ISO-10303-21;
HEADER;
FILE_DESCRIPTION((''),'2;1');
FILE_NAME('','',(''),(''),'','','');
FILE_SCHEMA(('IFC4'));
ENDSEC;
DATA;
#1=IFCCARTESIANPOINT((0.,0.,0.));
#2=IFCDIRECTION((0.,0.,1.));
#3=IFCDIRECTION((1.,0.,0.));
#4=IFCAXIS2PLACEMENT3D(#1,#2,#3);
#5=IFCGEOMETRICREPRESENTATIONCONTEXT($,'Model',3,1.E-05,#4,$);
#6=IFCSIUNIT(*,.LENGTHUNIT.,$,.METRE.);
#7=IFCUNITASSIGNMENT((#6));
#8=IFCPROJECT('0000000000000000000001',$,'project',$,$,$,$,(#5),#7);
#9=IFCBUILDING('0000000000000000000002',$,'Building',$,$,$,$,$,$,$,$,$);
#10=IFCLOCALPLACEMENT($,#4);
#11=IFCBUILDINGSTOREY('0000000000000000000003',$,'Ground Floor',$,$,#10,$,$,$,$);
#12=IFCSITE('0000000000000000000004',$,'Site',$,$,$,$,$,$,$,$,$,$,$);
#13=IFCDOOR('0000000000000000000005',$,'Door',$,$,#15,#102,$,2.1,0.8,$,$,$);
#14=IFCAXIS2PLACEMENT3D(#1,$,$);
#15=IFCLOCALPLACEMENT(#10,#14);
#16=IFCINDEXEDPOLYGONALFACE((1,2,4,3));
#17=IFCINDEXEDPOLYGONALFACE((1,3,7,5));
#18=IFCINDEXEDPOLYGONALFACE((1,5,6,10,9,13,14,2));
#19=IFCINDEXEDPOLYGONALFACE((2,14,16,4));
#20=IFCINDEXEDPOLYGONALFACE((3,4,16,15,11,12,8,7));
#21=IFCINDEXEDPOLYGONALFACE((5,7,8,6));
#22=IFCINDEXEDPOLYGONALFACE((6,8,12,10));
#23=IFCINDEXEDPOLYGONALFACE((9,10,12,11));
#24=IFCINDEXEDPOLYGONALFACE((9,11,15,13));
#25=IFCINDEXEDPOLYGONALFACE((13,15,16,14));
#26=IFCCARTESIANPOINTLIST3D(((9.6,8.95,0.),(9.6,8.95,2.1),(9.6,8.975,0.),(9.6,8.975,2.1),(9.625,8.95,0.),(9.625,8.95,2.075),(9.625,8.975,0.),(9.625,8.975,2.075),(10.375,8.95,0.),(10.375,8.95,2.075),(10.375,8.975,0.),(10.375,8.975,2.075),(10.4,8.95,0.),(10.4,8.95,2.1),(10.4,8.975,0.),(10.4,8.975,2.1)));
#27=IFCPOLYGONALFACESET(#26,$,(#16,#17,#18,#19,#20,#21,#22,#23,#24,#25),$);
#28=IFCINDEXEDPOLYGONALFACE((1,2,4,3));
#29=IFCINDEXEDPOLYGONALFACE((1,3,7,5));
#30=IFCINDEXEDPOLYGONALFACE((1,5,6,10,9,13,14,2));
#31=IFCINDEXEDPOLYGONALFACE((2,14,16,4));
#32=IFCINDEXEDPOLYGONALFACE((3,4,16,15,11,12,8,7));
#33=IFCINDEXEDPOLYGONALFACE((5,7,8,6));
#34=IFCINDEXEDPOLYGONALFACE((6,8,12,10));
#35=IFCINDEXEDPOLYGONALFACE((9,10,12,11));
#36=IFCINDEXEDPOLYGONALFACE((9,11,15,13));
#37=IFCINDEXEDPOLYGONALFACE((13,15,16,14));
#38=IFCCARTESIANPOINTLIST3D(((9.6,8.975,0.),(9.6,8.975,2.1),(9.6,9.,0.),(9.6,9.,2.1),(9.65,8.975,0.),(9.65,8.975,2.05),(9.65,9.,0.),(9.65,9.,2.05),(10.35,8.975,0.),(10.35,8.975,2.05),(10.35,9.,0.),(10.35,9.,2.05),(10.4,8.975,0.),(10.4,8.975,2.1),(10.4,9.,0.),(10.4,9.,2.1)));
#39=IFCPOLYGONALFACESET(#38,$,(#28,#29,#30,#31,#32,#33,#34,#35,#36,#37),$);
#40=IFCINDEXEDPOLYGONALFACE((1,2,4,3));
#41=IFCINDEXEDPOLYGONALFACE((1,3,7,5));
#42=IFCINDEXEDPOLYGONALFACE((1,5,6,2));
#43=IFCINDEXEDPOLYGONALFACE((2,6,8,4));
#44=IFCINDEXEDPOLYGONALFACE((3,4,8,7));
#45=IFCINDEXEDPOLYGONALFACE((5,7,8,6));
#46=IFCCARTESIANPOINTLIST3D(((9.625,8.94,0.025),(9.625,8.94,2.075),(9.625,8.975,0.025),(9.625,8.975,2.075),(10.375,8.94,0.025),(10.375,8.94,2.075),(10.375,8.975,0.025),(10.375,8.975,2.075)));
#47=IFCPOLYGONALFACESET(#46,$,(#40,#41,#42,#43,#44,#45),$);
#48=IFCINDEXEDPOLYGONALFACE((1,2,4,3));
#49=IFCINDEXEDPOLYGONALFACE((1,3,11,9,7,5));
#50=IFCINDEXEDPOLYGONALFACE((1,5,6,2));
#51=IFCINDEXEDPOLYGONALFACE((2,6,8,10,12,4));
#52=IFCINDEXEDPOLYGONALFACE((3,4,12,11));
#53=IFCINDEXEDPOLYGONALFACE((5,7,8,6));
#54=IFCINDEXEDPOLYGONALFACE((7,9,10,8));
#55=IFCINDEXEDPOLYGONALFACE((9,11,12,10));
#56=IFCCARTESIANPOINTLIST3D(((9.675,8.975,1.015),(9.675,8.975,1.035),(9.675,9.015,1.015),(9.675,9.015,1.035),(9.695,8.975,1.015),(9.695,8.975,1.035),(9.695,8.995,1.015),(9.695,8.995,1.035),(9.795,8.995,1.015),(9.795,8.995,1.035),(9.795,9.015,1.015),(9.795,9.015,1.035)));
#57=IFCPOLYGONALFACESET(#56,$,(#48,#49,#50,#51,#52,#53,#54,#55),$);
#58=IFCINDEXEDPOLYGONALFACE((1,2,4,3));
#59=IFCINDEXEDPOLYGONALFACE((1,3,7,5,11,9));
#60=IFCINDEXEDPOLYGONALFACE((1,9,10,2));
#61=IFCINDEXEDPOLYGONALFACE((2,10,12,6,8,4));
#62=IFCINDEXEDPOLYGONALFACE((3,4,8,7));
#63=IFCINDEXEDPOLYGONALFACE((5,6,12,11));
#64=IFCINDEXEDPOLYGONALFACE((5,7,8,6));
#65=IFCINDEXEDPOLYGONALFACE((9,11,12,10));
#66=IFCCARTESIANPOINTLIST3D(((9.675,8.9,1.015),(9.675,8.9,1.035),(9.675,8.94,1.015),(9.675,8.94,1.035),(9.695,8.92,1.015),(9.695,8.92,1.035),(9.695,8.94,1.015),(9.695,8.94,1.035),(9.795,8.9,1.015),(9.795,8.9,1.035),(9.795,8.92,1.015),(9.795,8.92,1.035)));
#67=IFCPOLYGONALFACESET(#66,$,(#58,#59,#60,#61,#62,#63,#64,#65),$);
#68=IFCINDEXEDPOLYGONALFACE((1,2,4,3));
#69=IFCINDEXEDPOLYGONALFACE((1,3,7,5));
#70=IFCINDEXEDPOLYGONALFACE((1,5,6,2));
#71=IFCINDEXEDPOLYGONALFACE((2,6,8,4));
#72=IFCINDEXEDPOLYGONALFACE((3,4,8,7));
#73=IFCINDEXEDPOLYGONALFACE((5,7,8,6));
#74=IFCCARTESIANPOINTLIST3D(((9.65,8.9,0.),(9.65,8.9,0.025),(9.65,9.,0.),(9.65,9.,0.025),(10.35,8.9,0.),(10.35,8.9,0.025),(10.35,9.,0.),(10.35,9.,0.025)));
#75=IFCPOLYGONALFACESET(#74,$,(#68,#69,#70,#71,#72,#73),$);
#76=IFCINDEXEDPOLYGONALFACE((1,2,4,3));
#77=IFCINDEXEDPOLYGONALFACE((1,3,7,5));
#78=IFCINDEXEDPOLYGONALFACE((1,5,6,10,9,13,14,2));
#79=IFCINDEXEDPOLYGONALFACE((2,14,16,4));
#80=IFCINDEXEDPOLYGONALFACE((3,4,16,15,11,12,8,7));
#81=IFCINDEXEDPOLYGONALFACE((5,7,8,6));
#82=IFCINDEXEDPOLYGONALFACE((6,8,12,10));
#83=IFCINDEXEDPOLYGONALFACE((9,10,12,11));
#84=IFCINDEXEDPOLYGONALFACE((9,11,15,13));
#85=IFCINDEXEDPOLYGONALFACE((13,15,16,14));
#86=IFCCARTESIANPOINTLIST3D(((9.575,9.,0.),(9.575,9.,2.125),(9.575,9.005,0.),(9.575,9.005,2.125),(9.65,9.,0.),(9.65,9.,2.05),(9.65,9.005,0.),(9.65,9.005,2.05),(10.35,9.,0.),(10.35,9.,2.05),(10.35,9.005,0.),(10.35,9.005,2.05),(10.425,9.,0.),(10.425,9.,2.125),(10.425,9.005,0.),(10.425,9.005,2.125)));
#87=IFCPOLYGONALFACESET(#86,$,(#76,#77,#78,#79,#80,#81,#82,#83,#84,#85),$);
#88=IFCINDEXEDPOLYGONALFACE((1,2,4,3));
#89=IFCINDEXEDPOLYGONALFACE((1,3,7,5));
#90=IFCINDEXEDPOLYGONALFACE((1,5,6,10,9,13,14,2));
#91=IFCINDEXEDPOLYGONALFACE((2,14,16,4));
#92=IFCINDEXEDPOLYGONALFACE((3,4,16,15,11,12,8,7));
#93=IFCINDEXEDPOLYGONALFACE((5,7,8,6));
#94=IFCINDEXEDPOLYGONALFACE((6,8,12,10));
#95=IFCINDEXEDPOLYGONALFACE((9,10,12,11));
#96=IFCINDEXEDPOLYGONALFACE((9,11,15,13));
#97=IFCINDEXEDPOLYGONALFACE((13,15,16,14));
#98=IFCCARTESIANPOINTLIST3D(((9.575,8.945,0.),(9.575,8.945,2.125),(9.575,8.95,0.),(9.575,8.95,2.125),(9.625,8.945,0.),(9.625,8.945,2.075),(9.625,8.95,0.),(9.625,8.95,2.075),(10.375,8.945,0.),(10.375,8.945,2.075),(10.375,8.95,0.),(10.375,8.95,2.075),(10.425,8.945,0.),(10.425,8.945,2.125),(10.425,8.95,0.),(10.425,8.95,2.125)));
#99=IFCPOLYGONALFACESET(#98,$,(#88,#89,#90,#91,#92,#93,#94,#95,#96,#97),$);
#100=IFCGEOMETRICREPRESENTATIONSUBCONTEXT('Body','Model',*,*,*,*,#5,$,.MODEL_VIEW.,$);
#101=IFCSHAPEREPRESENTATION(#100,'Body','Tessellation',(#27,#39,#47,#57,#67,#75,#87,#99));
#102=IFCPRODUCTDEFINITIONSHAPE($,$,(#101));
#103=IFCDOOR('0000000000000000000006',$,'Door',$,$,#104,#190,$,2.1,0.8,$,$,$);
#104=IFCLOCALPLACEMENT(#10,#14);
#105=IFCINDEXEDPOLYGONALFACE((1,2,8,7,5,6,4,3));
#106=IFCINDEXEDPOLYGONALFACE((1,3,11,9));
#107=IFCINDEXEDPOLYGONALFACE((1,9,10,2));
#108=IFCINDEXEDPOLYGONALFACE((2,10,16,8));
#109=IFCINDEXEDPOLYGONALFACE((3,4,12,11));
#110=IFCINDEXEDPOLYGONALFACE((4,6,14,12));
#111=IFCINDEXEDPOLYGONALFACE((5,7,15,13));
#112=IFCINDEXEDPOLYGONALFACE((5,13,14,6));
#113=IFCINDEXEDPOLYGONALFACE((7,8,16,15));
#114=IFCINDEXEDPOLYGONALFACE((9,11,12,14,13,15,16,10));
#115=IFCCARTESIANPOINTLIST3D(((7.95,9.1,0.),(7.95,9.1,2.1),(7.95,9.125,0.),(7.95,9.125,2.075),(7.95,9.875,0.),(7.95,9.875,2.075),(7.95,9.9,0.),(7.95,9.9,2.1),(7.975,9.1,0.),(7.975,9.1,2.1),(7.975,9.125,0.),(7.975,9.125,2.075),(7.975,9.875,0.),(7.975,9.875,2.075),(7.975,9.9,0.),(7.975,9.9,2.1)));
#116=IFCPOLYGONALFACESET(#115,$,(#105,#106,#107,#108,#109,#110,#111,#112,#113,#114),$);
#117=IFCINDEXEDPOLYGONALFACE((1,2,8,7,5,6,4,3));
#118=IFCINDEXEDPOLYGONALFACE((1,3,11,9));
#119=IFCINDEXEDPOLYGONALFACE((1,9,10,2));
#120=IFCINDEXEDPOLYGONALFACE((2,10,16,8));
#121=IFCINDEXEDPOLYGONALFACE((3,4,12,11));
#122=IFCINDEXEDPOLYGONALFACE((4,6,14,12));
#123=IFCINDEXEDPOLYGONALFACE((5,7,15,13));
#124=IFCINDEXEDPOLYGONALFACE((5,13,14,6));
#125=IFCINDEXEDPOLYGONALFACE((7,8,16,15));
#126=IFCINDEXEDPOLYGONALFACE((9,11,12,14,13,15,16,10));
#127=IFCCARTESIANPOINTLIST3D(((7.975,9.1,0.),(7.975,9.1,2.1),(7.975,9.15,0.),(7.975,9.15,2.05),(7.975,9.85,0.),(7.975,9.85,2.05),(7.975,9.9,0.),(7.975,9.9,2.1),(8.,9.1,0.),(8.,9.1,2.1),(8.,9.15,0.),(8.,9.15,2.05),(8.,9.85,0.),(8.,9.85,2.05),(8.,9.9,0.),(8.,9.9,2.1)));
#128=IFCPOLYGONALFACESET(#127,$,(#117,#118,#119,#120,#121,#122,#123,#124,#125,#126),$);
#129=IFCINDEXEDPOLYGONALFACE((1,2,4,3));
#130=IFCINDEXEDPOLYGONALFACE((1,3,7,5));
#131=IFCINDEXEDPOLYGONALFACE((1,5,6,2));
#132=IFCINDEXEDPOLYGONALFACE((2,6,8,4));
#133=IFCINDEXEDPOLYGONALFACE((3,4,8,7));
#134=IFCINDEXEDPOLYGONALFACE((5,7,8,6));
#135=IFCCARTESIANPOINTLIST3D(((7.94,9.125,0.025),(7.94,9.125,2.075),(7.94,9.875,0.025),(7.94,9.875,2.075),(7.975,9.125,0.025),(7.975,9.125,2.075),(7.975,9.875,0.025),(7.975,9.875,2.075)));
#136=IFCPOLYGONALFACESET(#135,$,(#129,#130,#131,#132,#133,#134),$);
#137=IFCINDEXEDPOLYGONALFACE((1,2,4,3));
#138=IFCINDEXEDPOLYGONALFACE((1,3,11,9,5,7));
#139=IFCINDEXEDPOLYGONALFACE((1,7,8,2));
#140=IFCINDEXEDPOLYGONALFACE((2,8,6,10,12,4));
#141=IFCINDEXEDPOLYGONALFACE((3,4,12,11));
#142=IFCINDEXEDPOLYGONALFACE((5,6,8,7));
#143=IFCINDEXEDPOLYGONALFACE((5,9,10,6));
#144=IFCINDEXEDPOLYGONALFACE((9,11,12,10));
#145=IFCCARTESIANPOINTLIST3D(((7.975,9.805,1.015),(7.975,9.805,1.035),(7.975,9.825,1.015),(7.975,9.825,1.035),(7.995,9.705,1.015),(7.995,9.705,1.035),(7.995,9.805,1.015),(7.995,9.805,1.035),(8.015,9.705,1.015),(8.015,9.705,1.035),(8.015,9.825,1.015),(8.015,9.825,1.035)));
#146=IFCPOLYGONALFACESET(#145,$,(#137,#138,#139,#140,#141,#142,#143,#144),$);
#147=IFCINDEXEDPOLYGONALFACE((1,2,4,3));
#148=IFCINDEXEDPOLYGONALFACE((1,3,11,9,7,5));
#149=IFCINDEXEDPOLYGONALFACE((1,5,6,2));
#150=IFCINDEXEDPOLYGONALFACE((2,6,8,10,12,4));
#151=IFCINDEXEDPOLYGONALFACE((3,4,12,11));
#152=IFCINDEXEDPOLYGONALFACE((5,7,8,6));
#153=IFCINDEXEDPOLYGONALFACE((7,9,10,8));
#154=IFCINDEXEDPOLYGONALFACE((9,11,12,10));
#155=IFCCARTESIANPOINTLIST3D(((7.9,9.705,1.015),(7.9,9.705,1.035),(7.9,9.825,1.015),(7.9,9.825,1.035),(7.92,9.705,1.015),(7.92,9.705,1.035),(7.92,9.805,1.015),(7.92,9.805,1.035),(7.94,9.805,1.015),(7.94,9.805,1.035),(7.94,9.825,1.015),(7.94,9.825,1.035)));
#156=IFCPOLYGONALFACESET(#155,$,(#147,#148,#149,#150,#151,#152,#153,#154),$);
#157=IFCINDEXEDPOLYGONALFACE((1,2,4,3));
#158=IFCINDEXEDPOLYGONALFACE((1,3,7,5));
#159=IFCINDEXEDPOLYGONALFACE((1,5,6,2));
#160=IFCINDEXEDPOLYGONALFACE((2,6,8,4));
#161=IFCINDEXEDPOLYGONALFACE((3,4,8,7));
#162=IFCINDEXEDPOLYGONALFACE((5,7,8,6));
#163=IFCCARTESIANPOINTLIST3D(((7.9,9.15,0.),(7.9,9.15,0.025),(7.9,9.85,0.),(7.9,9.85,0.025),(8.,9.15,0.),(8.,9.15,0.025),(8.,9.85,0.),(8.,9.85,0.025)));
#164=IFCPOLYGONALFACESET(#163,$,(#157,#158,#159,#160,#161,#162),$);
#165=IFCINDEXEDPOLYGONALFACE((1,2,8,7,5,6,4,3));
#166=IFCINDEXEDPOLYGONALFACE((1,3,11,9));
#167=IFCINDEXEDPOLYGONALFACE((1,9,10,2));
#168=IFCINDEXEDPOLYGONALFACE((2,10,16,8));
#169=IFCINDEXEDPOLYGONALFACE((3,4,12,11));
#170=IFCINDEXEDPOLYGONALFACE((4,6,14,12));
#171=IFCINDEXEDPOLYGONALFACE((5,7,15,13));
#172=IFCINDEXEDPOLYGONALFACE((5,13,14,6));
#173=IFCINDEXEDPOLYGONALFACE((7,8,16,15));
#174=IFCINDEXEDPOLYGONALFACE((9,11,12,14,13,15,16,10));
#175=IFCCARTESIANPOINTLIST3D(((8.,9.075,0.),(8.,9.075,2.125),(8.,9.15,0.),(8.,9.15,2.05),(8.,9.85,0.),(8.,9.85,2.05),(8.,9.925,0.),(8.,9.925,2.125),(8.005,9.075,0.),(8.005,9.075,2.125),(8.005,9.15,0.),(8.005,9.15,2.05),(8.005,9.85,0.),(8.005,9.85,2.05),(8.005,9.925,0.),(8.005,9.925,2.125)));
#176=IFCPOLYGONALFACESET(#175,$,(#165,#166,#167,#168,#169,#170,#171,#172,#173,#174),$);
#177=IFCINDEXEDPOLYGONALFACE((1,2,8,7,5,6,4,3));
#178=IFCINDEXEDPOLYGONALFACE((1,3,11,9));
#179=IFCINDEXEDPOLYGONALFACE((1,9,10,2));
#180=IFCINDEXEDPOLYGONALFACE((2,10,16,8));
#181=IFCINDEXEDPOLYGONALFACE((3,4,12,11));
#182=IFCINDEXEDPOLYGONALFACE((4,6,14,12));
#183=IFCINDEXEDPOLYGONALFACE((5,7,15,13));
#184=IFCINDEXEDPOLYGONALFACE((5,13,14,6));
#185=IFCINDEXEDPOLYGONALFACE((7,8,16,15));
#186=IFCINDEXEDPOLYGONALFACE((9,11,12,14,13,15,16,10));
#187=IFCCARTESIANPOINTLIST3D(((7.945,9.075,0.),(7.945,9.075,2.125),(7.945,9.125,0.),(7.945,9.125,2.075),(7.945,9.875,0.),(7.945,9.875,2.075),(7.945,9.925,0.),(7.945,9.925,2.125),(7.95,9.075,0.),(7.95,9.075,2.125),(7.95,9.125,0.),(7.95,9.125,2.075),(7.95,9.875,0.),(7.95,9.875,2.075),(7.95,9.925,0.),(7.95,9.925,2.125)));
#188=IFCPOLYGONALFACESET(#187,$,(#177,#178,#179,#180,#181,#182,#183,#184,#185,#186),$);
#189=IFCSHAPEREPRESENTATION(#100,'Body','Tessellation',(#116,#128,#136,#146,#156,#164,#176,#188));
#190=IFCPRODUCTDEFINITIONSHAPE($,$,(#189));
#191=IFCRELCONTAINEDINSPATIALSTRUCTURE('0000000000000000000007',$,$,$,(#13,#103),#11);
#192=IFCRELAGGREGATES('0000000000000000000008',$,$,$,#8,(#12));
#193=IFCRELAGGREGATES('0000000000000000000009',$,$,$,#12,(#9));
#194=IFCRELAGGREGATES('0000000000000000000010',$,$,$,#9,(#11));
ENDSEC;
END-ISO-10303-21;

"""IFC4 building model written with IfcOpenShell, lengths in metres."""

from ifc_helpers import new_model, si_unit, frame, origin_with_axes, place, context, subcontext, project, spatial, line, indexed_curve, outline, extrude, element, save


model = new_model("IFC4")

# Units and contexts
model_context = context("Model", 3, precision=1e-05, world=origin_with_axes())
body_context = subcontext(model_context, "Body", "Model", "MODEL_VIEW")
ifc_project = project(units=[si_unit("LENGTHUNIT", "METRE")], contexts=[model_context])

# Site, building, storey
site = spatial("IfcSite", under=ifc_project, Name="Site")
building = spatial("IfcBuilding", under=site, Name="Building")
storey_placement = place(None, origin_with_axes())
storey = spatial("IfcBuildingStorey", under=building, at=storey_placement, Name="Ground Floor")

# Doors
door_1_placement = place(storey_placement, frame((10.4, 9.0, 0.0), z_axis=(0.0, 0.0, 1.0), x_axis=(-1.0, 0.0, 0.0)))
element("IfcDoor", 1, at=door_1_placement, inside=storey, Name="Door", OverallHeight=2.1, OverallWidth=0.8, context=body_context, shape_type="SweptSolid", body=[
    extrude(outline(indexed_curve([(0.0, 0.0), (0.0, 2.1), (0.8, 2.1), (0.8, 0.0), (0.775, 0.0), (0.775, 2.075), (0.025, 2.075), (0.025, 0.0)], segments=[line(1, 2, 3, 4, 5, 6, 7, 8, 1)])), frame((0.0, 0.025, 0.0), z_axis=(0.0, -1.0, 0.0), x_axis=(1.0, 0.0, 0.0)), (0.0, 0.0, -1.0), 0.025),
    extrude(outline(indexed_curve([(0.0, 0.0), (0.0, 2.1), (0.8, 2.1), (0.8, 0.0), (0.75, 0.0), (0.75, 2.05), (0.05, 2.05), (0.05, 0.0)], segments=[line(1, 2, 3, 4, 5, 6, 7, 8, 1)])), frame((0.0, 0.0, 0.0), z_axis=(0.0, -1.0, 0.0), x_axis=(1.0, 0.0, 0.0)), (0.0, 0.0, -1.0), 0.025),
    extrude(outline(indexed_curve([(0.0, 0.0), (0.75, 0.0), (0.75, 0.035), (0.0, 0.035)], segments=[line(1, 2, 3, 4, 1)])), frame((0.025, 0.025, 0.025), z_axis=(0.0, 0.0, 1.0), x_axis=(1.0, 0.0, 0.0)), (0.0, 0.0, 1.0), 2.05),
    extrude(outline(indexed_curve([(0.0, 0.0), (0.0, -0.04), (-0.12, -0.04), (-0.12, -0.02), (-0.02, -0.02), (-0.02, 0.0)], segments=[line(1, 2, 3, 4, 5, 6, 1)])), frame((0.725, 0.025, 1.015), z_axis=(0.0, 0.0, 1.0), x_axis=(1.0, 0.0, 0.0)), (0.0, 0.0, 1.0), 0.02),
    extrude(outline(indexed_curve([(0.0, 0.0), (0.0, 0.04), (-0.12, 0.04), (-0.12, 0.02), (-0.02, 0.02), (-0.02, 0.0)], segments=[line(1, 2, 3, 4, 5, 6, 1)])), frame((0.725, 0.06, 1.015), z_axis=(0.0, 0.0, 1.0), x_axis=(1.0, 0.0, 0.0)), (0.0, 0.0, 1.0), 0.02),
    extrude(outline(indexed_curve([(0.0, 0.0), (0.7, 0.0), (0.7, 0.1), (0.0, 0.1)], segments=[line(1, 2, 3, 4, 1)])), frame((0.05, 0.0, 0.0), z_axis=(0.0, 0.0, 1.0), x_axis=(1.0, 0.0, 0.0)), (0.0, 0.0, 1.0), 0.025),
    extrude(outline(indexed_curve([(0.0, 0.0), (0.0, 2.125), (0.85, 2.125), (0.85, 0.0), (0.775, 0.0), (0.775, 2.05), (0.075, 2.05), (0.075, 0.0)], segments=[line(1, 2, 3, 4, 5, 6, 7, 8, 1)])), frame((-0.025, -0.005, 0.0), z_axis=(0.0, -1.0, 0.0), x_axis=(1.0, 0.0, 0.0)), (0.0, 0.0, -1.0), 0.005),
    extrude(outline(indexed_curve([(0.0, 0.0), (0.0, 2.125), (0.85, 2.125), (0.85, 0.0), (0.8, 0.0), (0.8, 2.075), (0.05, 2.075), (0.05, 0.0)], segments=[line(1, 2, 3, 4, 5, 6, 7, 8, 1)])), frame((-0.025, 0.05, 0.0), z_axis=(0.0, -1.0, 0.0), x_axis=(1.0, 0.0, 0.0)), (0.0, 0.0, -1.0), 0.005),
])
door_2_placement = place(storey_placement, frame((8.0, 9.1, 0.0), z_axis=(0.0, 0.0, 1.0), x_axis=(0.0, 1.0, 0.0)))
element("IfcDoor", 2, at=door_2_placement, inside=storey, Name="Door", OverallHeight=2.1, OverallWidth=0.8, context=body_context, shape_type="SweptSolid", body=[
    extrude(outline(indexed_curve([(0.0, 0.0), (0.0, 2.1), (0.8, 2.1), (0.8, 0.0), (0.775, 0.0), (0.775, 2.075), (0.025, 2.075), (0.025, 0.0)], segments=[line(1, 2, 3, 4, 5, 6, 7, 8, 1)])), frame((0.0, 0.025, 0.0), z_axis=(0.0, -1.0, 0.0), x_axis=(1.0, 0.0, 0.0)), (0.0, 0.0, -1.0), 0.025),
    extrude(outline(indexed_curve([(0.0, 0.0), (0.0, 2.1), (0.8, 2.1), (0.8, 0.0), (0.75, 0.0), (0.75, 2.05), (0.05, 2.05), (0.05, 0.0)], segments=[line(1, 2, 3, 4, 5, 6, 7, 8, 1)])), frame((0.0, 0.0, 0.0), z_axis=(0.0, -1.0, 0.0), x_axis=(1.0, 0.0, 0.0)), (0.0, 0.0, -1.0), 0.025),
    extrude(outline(indexed_curve([(0.0, 0.0), (0.75, 0.0), (0.75, 0.035), (0.0, 0.035)], segments=[line(1, 2, 3, 4, 1)])), frame((0.025, 0.025, 0.025), z_axis=(0.0, 0.0, 1.0), x_axis=(1.0, 0.0, 0.0)), (0.0, 0.0, 1.0), 2.05),
    extrude(outline(indexed_curve([(0.0, 0.0), (0.0, -0.04), (-0.12, -0.04), (-0.12, -0.02), (-0.02, -0.02), (-0.02, 0.0)], segments=[line(1, 2, 3, 4, 5, 6, 1)])), frame((0.725, 0.025, 1.015), z_axis=(0.0, 0.0, 1.0), x_axis=(1.0, 0.0, 0.0)), (0.0, 0.0, 1.0), 0.02),
    extrude(outline(indexed_curve([(0.0, 0.0), (0.0, 0.04), (-0.12, 0.04), (-0.12, 0.02), (-0.02, 0.02), (-0.02, 0.0)], segments=[line(1, 2, 3, 4, 5, 6, 1)])), frame((0.725, 0.06, 1.015), z_axis=(0.0, 0.0, 1.0), x_axis=(1.0, 0.0, 0.0)), (0.0, 0.0, 1.0), 0.02),
    extrude(outline(indexed_curve([(0.0, 0.0), (0.7, 0.0), (0.7, 0.1), (0.0, 0.1)], segments=[line(1, 2, 3, 4, 1)])), frame((0.05, 0.0, 0.0), z_axis=(0.0, 0.0, 1.0), x_axis=(1.0, 0.0, 0.0)), (0.0, 0.0, 1.0), 0.025),
    extrude(outline(indexed_curve([(0.0, 0.0), (0.0, 2.125), (0.85, 2.125), (0.85, 0.0), (0.775, 0.0), (0.775, 2.05), (0.075, 2.05), (0.075, 0.0)], segments=[line(1, 2, 3, 4, 5, 6, 7, 8, 1)])), frame((-0.025, -0.005, 0.0), z_axis=(0.0, -1.0, 0.0), x_axis=(1.0, 0.0, 0.0)), (0.0, 0.0, -1.0), 0.005),
    extrude(outline(indexed_curve([(0.0, 0.0), (0.0, 2.125), (0.85, 2.125), (0.85, 0.0), (0.8, 0.0), (0.8, 2.075), (0.05, 2.075), (0.05, 0.0)], segments=[line(1, 2, 3, 4, 5, 6, 7, 8, 1)])), frame((-0.025, 0.05, 0.0), z_axis=(0.0, -1.0, 0.0), x_axis=(1.0, 0.0, 0.0)), (0.0, 0.0, -1.0), 0.005),
])

save(model, "model.ifc")
